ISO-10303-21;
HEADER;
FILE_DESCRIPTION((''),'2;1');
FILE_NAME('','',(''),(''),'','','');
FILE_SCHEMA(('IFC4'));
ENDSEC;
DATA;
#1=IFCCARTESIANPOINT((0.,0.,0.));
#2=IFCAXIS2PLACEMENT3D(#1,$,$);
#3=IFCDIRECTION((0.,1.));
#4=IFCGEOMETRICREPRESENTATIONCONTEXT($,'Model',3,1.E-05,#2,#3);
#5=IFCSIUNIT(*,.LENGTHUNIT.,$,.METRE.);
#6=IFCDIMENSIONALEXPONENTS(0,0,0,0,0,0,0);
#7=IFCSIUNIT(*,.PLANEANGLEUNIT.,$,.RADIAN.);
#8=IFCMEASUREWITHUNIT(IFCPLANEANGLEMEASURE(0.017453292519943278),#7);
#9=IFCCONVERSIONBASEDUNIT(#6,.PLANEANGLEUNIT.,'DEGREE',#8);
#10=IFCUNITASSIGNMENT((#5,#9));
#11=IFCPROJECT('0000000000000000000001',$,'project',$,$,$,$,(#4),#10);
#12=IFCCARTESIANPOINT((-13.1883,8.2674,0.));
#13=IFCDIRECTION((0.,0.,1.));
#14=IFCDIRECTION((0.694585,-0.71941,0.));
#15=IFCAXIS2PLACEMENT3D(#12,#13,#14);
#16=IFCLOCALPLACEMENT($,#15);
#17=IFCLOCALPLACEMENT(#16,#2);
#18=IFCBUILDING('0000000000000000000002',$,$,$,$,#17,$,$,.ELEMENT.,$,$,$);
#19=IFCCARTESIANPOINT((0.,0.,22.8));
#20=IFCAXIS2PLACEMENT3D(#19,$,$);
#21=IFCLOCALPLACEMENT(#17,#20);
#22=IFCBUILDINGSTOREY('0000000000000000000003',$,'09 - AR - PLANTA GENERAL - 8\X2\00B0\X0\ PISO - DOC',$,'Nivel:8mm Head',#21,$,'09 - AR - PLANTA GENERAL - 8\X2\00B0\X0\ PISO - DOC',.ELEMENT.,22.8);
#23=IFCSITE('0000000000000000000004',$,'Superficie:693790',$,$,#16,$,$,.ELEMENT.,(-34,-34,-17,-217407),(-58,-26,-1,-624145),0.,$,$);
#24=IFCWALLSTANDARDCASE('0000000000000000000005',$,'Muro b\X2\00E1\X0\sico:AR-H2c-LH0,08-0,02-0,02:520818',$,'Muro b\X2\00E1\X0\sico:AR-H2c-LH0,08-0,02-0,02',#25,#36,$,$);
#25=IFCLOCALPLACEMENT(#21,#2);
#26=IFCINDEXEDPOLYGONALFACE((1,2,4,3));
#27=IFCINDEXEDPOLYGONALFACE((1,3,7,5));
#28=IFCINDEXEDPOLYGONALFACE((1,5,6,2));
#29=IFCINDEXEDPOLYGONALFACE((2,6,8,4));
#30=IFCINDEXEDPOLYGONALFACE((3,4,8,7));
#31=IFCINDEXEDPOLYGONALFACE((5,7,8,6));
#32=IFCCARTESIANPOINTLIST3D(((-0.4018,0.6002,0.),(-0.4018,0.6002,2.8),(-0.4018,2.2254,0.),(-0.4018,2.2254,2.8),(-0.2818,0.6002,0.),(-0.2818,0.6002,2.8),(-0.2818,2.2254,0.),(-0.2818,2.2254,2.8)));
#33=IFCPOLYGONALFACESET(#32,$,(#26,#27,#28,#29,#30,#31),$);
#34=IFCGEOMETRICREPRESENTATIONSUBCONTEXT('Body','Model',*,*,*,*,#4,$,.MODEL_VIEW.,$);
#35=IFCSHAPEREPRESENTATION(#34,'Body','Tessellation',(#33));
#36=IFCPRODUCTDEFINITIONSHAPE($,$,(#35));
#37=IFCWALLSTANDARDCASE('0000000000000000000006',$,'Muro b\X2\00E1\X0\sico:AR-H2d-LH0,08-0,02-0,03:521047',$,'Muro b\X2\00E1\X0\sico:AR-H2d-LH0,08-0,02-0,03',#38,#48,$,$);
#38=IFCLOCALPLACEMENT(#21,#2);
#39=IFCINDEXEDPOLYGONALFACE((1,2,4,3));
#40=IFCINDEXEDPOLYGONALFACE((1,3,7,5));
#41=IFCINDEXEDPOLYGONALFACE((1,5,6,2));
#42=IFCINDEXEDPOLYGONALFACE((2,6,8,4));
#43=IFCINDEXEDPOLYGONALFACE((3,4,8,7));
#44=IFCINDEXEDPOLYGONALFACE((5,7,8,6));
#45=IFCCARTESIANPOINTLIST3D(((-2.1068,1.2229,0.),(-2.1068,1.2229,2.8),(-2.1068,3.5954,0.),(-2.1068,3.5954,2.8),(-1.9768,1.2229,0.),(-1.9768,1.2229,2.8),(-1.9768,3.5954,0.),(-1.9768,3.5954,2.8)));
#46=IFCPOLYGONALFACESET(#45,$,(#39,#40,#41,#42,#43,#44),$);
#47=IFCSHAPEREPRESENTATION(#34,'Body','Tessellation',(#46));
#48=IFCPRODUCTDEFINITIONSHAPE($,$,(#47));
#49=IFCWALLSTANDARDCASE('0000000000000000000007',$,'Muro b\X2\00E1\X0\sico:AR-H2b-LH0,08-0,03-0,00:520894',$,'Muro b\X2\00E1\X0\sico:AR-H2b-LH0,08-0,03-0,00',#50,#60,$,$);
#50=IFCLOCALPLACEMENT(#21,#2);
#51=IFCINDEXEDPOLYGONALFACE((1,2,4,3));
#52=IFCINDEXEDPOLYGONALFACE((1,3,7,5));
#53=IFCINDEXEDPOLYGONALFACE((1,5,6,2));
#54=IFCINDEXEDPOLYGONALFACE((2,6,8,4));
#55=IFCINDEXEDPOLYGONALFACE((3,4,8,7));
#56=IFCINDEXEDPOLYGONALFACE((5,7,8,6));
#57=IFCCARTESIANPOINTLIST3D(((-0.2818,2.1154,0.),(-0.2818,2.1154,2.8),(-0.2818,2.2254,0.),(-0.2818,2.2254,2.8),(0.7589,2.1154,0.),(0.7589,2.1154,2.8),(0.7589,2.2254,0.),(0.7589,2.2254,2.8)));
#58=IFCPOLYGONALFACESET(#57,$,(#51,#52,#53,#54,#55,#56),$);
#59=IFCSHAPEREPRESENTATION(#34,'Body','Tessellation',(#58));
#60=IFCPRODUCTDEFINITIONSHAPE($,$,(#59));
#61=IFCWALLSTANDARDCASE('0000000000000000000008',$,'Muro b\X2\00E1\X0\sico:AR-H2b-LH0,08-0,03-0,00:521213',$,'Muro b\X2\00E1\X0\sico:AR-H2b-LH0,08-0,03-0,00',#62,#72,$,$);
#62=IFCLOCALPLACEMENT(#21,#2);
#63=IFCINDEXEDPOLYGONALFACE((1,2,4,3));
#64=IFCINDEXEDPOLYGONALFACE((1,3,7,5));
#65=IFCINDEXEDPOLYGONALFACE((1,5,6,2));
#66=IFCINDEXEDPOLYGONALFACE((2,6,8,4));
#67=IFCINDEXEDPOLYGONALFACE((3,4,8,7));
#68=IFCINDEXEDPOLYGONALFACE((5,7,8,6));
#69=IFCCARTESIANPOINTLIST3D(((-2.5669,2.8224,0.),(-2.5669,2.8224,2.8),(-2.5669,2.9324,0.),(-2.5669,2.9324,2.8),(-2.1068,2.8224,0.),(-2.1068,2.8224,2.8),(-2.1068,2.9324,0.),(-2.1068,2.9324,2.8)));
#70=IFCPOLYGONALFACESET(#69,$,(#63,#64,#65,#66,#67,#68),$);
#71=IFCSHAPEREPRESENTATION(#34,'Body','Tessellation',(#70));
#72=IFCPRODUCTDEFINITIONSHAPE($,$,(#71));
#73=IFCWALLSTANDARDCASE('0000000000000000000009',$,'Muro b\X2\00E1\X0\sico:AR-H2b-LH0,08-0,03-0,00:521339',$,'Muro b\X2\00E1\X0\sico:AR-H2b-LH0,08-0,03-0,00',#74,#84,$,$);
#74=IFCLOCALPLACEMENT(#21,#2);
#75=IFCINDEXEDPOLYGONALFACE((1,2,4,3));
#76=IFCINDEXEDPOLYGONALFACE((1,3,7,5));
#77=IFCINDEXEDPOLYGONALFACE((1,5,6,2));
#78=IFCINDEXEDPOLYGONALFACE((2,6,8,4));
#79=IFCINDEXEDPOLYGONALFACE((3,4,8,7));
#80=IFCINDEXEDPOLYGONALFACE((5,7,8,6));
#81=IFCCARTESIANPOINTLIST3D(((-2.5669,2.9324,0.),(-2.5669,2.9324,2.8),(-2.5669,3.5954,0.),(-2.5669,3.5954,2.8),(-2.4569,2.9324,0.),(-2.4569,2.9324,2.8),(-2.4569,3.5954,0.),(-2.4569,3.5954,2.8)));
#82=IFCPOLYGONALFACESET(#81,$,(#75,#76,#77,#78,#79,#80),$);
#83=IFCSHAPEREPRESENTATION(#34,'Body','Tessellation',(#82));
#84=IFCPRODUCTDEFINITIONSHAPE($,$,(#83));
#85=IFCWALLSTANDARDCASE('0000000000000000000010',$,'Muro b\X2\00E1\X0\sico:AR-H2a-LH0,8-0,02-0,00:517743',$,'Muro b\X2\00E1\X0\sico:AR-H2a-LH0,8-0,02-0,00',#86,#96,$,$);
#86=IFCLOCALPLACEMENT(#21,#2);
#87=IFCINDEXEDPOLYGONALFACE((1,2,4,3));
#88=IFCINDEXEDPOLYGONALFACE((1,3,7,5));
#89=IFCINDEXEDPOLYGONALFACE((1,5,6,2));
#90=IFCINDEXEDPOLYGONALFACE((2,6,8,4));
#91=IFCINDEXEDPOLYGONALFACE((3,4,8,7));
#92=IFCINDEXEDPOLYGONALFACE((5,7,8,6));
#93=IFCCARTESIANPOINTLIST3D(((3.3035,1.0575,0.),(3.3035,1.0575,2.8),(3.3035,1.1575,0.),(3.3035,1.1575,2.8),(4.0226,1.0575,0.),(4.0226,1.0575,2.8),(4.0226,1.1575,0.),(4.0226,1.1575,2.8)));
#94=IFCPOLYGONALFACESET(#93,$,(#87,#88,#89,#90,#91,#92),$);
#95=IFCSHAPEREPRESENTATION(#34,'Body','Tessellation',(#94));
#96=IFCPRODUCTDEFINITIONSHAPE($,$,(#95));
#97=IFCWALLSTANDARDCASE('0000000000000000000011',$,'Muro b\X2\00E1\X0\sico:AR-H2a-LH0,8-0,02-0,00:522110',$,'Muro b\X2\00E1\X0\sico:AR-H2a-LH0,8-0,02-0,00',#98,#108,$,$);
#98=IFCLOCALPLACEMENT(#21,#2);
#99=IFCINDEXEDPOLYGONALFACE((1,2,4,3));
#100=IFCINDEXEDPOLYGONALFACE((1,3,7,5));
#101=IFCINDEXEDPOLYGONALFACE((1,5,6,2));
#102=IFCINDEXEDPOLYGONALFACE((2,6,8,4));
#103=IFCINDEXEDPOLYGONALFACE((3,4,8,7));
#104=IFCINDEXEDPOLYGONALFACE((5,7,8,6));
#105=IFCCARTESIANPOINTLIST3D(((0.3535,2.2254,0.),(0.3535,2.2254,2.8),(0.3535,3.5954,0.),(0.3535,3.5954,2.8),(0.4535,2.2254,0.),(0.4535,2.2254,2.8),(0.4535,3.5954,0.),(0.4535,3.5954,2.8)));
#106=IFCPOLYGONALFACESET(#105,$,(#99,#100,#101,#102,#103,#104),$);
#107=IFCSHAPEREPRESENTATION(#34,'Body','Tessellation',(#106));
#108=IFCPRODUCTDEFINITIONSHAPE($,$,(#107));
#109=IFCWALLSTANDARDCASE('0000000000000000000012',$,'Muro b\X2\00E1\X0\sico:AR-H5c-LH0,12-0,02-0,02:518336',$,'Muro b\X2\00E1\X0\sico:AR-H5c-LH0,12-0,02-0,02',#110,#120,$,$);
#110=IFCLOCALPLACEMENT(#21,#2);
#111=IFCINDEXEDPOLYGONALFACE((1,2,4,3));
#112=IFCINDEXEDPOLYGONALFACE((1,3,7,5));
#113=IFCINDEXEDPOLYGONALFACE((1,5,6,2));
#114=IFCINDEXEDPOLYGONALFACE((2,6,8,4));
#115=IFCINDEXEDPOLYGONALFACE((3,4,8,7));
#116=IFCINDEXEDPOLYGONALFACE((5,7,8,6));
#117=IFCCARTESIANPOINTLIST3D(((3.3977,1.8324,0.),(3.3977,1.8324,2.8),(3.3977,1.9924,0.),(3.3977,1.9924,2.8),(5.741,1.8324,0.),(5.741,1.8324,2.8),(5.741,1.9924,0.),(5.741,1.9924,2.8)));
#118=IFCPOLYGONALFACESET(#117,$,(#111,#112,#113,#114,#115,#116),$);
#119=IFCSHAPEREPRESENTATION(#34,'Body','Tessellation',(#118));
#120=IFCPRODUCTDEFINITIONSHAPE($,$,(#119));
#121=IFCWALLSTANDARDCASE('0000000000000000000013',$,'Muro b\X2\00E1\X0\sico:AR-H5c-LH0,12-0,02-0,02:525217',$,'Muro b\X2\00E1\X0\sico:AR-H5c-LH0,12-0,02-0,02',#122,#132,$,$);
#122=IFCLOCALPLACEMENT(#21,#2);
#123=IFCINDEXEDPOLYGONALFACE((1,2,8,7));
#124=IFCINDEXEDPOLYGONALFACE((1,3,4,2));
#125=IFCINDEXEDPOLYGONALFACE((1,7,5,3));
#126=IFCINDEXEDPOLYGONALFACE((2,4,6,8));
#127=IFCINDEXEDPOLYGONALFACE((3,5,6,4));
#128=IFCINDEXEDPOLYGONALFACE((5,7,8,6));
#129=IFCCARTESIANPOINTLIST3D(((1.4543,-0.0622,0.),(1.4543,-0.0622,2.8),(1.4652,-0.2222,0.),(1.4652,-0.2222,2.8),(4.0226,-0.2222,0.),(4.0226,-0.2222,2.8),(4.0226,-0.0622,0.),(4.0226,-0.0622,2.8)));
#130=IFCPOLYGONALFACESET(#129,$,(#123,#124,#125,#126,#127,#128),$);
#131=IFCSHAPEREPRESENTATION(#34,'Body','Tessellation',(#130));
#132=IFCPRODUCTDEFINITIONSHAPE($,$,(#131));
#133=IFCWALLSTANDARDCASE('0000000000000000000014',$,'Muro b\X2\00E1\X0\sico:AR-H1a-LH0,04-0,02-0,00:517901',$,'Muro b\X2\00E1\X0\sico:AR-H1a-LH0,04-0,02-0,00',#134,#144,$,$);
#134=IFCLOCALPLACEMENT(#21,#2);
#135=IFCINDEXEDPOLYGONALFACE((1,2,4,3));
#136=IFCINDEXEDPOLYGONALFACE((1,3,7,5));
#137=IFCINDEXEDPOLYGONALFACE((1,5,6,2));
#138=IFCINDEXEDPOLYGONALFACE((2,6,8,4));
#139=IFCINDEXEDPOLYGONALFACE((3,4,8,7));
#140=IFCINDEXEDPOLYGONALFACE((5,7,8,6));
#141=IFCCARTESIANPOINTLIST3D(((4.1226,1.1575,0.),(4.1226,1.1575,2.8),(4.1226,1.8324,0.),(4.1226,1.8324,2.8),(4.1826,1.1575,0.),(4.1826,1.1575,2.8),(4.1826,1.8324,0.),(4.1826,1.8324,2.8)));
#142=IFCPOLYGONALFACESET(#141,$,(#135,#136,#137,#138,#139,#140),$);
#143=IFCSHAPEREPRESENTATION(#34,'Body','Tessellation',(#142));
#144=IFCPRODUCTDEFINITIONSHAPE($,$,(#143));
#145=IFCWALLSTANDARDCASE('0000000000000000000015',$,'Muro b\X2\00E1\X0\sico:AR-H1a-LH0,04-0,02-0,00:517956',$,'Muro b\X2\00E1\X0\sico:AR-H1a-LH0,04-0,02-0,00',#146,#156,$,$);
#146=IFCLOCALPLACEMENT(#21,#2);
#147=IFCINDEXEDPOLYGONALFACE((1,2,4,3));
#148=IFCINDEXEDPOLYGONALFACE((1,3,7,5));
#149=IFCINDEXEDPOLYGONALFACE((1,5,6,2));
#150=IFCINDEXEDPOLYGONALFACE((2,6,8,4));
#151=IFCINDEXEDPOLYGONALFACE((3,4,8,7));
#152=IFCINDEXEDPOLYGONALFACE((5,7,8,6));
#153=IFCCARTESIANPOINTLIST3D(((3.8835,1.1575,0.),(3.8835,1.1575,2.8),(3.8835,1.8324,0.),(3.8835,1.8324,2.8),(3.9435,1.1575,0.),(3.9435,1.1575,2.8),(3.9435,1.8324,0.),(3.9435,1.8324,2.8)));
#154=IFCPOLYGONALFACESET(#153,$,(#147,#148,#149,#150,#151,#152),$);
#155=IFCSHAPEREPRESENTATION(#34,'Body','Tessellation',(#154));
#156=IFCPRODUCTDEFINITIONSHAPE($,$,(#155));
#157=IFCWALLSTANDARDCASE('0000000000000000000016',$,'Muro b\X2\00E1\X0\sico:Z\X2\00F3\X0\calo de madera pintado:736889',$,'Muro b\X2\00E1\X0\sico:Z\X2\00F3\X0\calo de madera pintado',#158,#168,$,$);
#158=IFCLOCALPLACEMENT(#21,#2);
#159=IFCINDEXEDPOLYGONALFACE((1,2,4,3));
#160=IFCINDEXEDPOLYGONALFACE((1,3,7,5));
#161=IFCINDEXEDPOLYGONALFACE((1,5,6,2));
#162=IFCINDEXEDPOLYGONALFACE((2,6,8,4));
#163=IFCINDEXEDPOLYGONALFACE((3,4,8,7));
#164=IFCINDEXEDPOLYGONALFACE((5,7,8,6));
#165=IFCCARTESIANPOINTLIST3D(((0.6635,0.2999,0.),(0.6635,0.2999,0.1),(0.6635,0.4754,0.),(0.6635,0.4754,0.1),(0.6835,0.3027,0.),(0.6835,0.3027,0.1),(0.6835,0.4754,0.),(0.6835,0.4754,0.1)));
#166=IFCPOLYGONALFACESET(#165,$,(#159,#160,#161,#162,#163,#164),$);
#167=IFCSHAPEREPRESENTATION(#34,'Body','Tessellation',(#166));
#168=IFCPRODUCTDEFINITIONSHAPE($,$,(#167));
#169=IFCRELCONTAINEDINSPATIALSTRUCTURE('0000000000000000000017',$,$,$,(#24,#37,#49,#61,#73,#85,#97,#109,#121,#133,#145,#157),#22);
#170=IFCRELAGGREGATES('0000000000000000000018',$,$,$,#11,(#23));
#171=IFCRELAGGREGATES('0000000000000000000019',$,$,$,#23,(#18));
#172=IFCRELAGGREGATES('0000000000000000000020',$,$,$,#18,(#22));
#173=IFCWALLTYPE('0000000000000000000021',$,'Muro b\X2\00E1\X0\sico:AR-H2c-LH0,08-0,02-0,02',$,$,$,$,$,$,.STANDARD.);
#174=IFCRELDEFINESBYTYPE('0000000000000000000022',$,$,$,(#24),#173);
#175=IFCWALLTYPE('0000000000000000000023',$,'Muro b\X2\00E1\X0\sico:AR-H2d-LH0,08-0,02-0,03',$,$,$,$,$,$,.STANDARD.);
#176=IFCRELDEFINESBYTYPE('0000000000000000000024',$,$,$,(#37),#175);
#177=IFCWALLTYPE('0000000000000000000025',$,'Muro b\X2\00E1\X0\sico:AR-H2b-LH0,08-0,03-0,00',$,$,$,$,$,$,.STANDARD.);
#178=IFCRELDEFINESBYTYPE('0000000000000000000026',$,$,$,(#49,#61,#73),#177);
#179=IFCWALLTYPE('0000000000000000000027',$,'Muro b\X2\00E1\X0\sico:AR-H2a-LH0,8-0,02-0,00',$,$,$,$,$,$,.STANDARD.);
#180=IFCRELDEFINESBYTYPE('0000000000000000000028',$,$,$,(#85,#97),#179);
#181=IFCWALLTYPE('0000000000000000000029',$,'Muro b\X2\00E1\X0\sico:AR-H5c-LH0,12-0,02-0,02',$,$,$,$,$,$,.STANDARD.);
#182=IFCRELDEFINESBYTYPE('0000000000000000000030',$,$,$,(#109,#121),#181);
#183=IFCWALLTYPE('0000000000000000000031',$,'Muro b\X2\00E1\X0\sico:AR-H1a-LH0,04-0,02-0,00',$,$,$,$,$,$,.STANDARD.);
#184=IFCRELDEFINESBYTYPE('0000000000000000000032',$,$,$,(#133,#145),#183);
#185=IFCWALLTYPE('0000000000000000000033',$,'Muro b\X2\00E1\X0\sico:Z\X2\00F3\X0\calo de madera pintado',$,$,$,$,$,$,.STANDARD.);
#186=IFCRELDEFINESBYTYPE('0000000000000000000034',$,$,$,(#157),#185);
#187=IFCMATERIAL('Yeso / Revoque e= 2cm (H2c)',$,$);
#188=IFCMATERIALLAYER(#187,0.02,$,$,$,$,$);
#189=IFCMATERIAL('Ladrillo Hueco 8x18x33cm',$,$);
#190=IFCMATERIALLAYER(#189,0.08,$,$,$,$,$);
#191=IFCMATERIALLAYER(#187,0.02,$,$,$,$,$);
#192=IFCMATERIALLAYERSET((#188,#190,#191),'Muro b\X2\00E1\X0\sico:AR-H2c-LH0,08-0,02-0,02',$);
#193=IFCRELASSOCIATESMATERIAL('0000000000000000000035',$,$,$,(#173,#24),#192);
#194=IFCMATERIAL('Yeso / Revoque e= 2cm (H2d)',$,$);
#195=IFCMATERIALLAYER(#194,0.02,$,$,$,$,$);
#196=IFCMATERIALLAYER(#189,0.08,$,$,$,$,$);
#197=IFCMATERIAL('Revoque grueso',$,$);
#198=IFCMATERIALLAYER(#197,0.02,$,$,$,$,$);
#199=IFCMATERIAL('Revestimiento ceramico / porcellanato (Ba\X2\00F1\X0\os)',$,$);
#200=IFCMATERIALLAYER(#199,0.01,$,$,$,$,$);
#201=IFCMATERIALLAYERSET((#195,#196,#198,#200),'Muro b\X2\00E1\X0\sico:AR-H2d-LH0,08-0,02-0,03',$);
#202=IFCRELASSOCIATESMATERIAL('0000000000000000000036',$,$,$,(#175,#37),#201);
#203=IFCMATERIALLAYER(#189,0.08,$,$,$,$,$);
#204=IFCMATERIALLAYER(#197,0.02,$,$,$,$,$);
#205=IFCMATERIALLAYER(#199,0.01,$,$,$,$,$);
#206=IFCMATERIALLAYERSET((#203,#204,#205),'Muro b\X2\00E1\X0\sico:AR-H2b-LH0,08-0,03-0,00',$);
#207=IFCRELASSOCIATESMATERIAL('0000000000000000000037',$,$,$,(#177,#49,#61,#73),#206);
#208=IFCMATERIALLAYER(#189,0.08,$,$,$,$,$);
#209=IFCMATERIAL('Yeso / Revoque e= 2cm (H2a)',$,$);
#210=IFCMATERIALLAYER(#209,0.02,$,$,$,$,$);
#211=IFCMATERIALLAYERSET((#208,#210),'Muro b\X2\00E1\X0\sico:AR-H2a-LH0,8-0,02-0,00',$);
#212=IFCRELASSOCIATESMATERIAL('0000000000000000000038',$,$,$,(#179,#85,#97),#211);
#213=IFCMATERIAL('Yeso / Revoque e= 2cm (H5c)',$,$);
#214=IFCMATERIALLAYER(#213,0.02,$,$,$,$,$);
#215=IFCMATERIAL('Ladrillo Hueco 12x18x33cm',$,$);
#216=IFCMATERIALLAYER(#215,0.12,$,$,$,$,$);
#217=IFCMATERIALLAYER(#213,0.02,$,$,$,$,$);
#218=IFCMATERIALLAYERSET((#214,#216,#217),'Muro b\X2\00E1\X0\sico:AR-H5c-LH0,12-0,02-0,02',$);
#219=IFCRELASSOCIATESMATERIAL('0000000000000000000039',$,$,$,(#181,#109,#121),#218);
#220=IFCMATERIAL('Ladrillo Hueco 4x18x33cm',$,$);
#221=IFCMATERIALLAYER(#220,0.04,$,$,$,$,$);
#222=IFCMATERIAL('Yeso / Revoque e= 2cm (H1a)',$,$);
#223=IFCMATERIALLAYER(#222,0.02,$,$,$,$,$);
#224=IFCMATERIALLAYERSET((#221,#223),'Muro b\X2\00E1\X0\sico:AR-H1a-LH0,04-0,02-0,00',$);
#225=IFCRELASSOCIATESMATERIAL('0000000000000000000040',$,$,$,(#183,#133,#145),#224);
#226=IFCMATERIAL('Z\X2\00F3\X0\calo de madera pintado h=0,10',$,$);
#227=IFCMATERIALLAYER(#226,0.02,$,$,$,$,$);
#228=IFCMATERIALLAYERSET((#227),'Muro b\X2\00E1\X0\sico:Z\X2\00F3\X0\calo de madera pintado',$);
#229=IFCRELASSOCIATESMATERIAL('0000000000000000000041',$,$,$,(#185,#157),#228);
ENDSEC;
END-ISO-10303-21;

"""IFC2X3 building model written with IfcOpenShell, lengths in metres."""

from ifc_helpers import new_model, entity, si_unit, converted_unit, direction, frame, frame_2d, origin, place, context, subcontext, project, spatial, polyline, rectangle, outline, extrude, material, layer, layer_set, layer_usage, type_object, element, save


model = new_model("IFC2X3")

# Units and contexts
model_context = context("Model", 3, precision=1e-05, world=origin(), true_north=direction((0.0, 1.0)))
body_context = subcontext(model_context, "Body", "Model", "MODEL_VIEW")
ifc_project = project(units=[si_unit("LENGTHUNIT", "METRE"), converted_unit("PLANEANGLEUNIT", "DEGREE", entity("IfcPlaneAngleMeasure", 0.017453292519943278), si_unit("PLANEANGLEUNIT", "RADIAN"), dimensions=[0, 0, 0, 0, 0, 0, 0])], contexts=[model_context])

# Site, building, storey
site_placement = place(None, frame((-13.1883, 8.2674, 0.0), z_axis=(0.0, 0.0, 1.0), x_axis=(0.694585, -0.71941, 0.0)))
site = spatial("IfcSite", under=ifc_project, at=site_placement, Name="Superficie:693790", CompositionType="ELEMENT", RefLatitude=(-34, -34, -17, -217407), RefLongitude=(-58, -26, -1, -624145), RefElevation=0.0)
building_placement = place(site_placement, origin())
building = spatial("IfcBuilding", under=site, at=building_placement, CompositionType="ELEMENT")
storey_placement = place(building_placement, frame((0.0, 0.0, 22.8)))
storey = spatial("IfcBuildingStorey", under=building, at=storey_placement, Name="09 - AR - PLANTA GENERAL - 8° PISO - DOC", ObjectType="Nivel:8mm Head", LongName="09 - AR - PLANTA GENERAL - 8° PISO - DOC", CompositionType="ELEMENT", Elevation=22.8)

# Walls
ifc_material_1 = material(Name="Yeso / Revoque e= 2cm (H2c)")
ifc_layer_1 = layer(ifc_material_1, 0.02)
ifc_material_2 = material(Name="Ladrillo Hueco 8x18x33cm")
ifc_layer_2 = layer(ifc_material_2, 0.08)
ifc_layer_3 = layer(ifc_material_1, 0.02)
ifc_layer_set_1 = layer_set([ifc_layer_1, ifc_layer_2, ifc_layer_3], Name="Muro básico:AR-H2c-LH0,08-0,02-0,02")
ifc_layer_usage_1 = layer_usage(ifc_layer_set_1, "AXIS2", "NEGATIVE", 0.06)
wall_type_1 = type_object("IfcWallType", Name="Muro básico:AR-H2c-LH0,08-0,02-0,02", PredefinedType="STANDARD", material=ifc_layer_set_1)
wall_1_placement = place(storey_placement, frame((-0.3418, 0.6002, 0.0), z_axis=(0.0, 0.0, 1.0), x_axis=(0.0, 1.0, 0.0)))
element("IfcWallStandardCase", 1, at=wall_1_placement, inside=storey, type_object=wall_type_1, material=ifc_layer_usage_1, Name="Muro básico:AR-H2c-LH0,08-0,02-0,02:520818", ObjectType="Muro básico:AR-H2c-LH0,08-0,02-0,02", context=body_context, shape_type="SweptSolid", body=[
    extrude(rectangle(XDim=1.6252, YDim=0.12, at=frame_2d((0.8126, 0.0), x_axis=(-1.0, 0.0))), origin(), (0.0, 0.0, 1.0), 2.8),
])
ifc_material_3 = material(Name="Yeso / Revoque e= 2cm (H2d)")
ifc_layer_4 = layer(ifc_material_3, 0.02)
ifc_layer_5 = layer(ifc_material_2, 0.08)
ifc_material_4 = material(Name="Revoque grueso")
ifc_layer_6 = layer(ifc_material_4, 0.02)
ifc_material_5 = material(Name="Revestimiento ceramico / porcellanato (Baños)")
ifc_layer_7 = layer(ifc_material_5, 0.01)
ifc_layer_set_2 = layer_set([ifc_layer_4, ifc_layer_5, ifc_layer_6, ifc_layer_7], Name="Muro básico:AR-H2d-LH0,08-0,02-0,03")
ifc_layer_usage_2 = layer_usage(ifc_layer_set_2, "AXIS2", "NEGATIVE", 0.065)
wall_type_2 = type_object("IfcWallType", Name="Muro básico:AR-H2d-LH0,08-0,02-0,03", PredefinedType="STANDARD", material=ifc_layer_set_2)
wall_2_placement = place(storey_placement, frame((-2.0418, 3.5954, 0.0), z_axis=(0.0, 0.0, 1.0), x_axis=(0.0, -1.0, 0.0)))
element("IfcWallStandardCase", 2, at=wall_2_placement, inside=storey, type_object=wall_type_2, material=ifc_layer_usage_2, Name="Muro básico:AR-H2d-LH0,08-0,02-0,03:521047", ObjectType="Muro básico:AR-H2d-LH0,08-0,02-0,03", context=body_context, shape_type="SweptSolid", body=[
    extrude(rectangle(XDim=2.3725, YDim=0.13, at=frame_2d((1.1862, 0.0), x_axis=(-1.0, 0.0))), origin(), (0.0, 0.0, 1.0), 2.8),
])
ifc_layer_8 = layer(ifc_material_2, 0.08)
ifc_layer_9 = layer(ifc_material_4, 0.02)
ifc_layer_10 = layer(ifc_material_5, 0.01)
ifc_layer_set_3 = layer_set([ifc_layer_8, ifc_layer_9, ifc_layer_10], Name="Muro básico:AR-H2b-LH0,08-0,03-0,00")
ifc_layer_usage_3 = layer_usage(ifc_layer_set_3, "AXIS2", "POSITIVE", -0.055)
wall_type_3 = type_object("IfcWallType", Name="Muro básico:AR-H2b-LH0,08-0,03-0,00", PredefinedType="STANDARD", material=ifc_layer_set_3)
wall_3_placement = place(storey_placement, frame((-0.2818, 2.1704, 0.0)))
element("IfcWallStandardCase", 3, at=wall_3_placement, inside=storey, type_object=wall_type_3, material=ifc_layer_usage_3, Name="Muro básico:AR-H2b-LH0,08-0,03-0,00:520894", ObjectType="Muro básico:AR-H2b-LH0,08-0,03-0,00", context=body_context, shape_type="SweptSolid", body=[
    extrude(rectangle(XDim=1.0408, YDim=0.11, at=frame_2d((0.5204, 0.0), x_axis=(-1.0, 0.0))), origin(), (0.0, 0.0, 1.0), 2.8),
])
ifc_layer_usage_4 = layer_usage(ifc_layer_set_3, "AXIS2", "POSITIVE", -0.055)
wall_4_placement = place(storey_placement, frame((-2.1068, 2.8774, 0.0), z_axis=(0.0, 0.0, 1.0), x_axis=(-1.0, 0.0, 0.0)))
element("IfcWallStandardCase", 4, at=wall_4_placement, inside=storey, type_object=wall_type_3, material=ifc_layer_usage_4, Name="Muro básico:AR-H2b-LH0,08-0,03-0,00:521213", ObjectType="Muro básico:AR-H2b-LH0,08-0,03-0,00", context=body_context, shape_type="SweptSolid", body=[
    extrude(rectangle(XDim=0.46, YDim=0.11, at=frame_2d((0.23, 0.0), x_axis=(-1.0, 0.0))), origin(), (0.0, 0.0, 1.0), 2.8),
])
ifc_layer_usage_5 = layer_usage(ifc_layer_set_3, "AXIS2", "POSITIVE", -0.055)
wall_5_placement = place(storey_placement, frame((-2.5119, 2.9324, 0.0), z_axis=(0.0, 0.0, 1.0), x_axis=(0.0, 1.0, 0.0)))
element("IfcWallStandardCase", 5, at=wall_5_placement, inside=storey, type_object=wall_type_3, material=ifc_layer_usage_5, Name="Muro básico:AR-H2b-LH0,08-0,03-0,00:521339", ObjectType="Muro básico:AR-H2b-LH0,08-0,03-0,00", context=body_context, shape_type="SweptSolid", body=[
    extrude(rectangle(XDim=0.663, YDim=0.11, at=frame_2d((0.3315, 0.0), x_axis=(-1.0, 0.0))), origin(), (0.0, 0.0, 1.0), 2.8),
])
ifc_layer_11 = layer(ifc_material_2, 0.08)
ifc_material_6 = material(Name="Yeso / Revoque e= 2cm (H2a)")
ifc_layer_12 = layer(ifc_material_6, 0.02)
ifc_layer_set_4 = layer_set([ifc_layer_11, ifc_layer_12], Name="Muro básico:AR-H2a-LH0,8-0,02-0,00")
ifc_layer_usage_6 = layer_usage(ifc_layer_set_4, "AXIS2", "POSITIVE", -0.05)
wall_type_4 = type_object("IfcWallType", Name="Muro básico:AR-H2a-LH0,8-0,02-0,00", PredefinedType="STANDARD", material=ifc_layer_set_4)
wall_6_placement = place(storey_placement, frame((4.0226, 1.1075, 0.0), z_axis=(0.0, 0.0, 1.0), x_axis=(-1.0, 0.0, 0.0)))
element("IfcWallStandardCase", 6, at=wall_6_placement, inside=storey, type_object=wall_type_4, material=ifc_layer_usage_6, Name="Muro básico:AR-H2a-LH0,8-0,02-0,00:517743", ObjectType="Muro básico:AR-H2a-LH0,8-0,02-0,00", context=body_context, shape_type="SweptSolid", body=[
    extrude(rectangle(XDim=0.7191, YDim=0.1, at=frame_2d((0.3595, 0.0), x_axis=(-1.0, 0.0))), origin(), (0.0, 0.0, 1.0), 2.8),
])
ifc_layer_usage_7 = layer_usage(ifc_layer_set_4, "AXIS2", "NEGATIVE", 0.05)
wall_7_placement = place(storey_placement, frame((0.4035, 3.5954, 0.0), z_axis=(0.0, 0.0, 1.0), x_axis=(0.0, -1.0, 0.0)))
element("IfcWallStandardCase", 7, at=wall_7_placement, inside=storey, type_object=wall_type_4, material=ifc_layer_usage_7, Name="Muro básico:AR-H2a-LH0,8-0,02-0,00:522110", ObjectType="Muro básico:AR-H2a-LH0,8-0,02-0,00", context=body_context, shape_type="SweptSolid", body=[
    extrude(rectangle(XDim=1.3701, YDim=0.1, at=frame_2d((0.685, 0.0), x_axis=(-1.0, 0.0))), origin(), (0.0, 0.0, 1.0), 2.8),
])
ifc_material_7 = material(Name="Yeso / Revoque e= 2cm (H5c)")
ifc_layer_13 = layer(ifc_material_7, 0.02)
ifc_material_8 = material(Name="Ladrillo Hueco 12x18x33cm")
ifc_layer_14 = layer(ifc_material_8, 0.12)
ifc_layer_15 = layer(ifc_material_7, 0.02)
ifc_layer_set_5 = layer_set([ifc_layer_13, ifc_layer_14, ifc_layer_15], Name="Muro básico:AR-H5c-LH0,12-0,02-0,02")
ifc_layer_usage_8 = layer_usage(ifc_layer_set_5, "AXIS2", "POSITIVE", -0.08)
wall_type_5 = type_object("IfcWallType", Name="Muro básico:AR-H5c-LH0,12-0,02-0,02", PredefinedType="STANDARD", material=ifc_layer_set_5)
wall_8_placement = place(storey_placement, frame((5.741, 1.9124, 0.0), z_axis=(0.0, 0.0, 1.0), x_axis=(-1.0, 0.0, 0.0)))
element("IfcWallStandardCase", 8, at=wall_8_placement, inside=storey, type_object=wall_type_5, material=ifc_layer_usage_8, Name="Muro básico:AR-H5c-LH0,12-0,02-0,02:518336", ObjectType="Muro básico:AR-H5c-LH0,12-0,02-0,02", context=body_context, shape_type="SweptSolid", body=[
    extrude(rectangle(XDim=2.3433, YDim=0.16, at=frame_2d((1.1716, 0.0), x_axis=(-1.0, 0.0))), origin(), (0.0, 0.0, 1.0), 2.8),
])
ifc_layer_usage_9 = layer_usage(ifc_layer_set_5, "AXIS2", "NEGATIVE", 0.08)
wall_9_placement = place(storey_placement, frame((1.4543, -0.1422, 0.0)))
element("IfcWallStandardCase", 9, at=wall_9_placement, inside=storey, type_object=wall_type_5, material=ifc_layer_usage_9, Name="Muro básico:AR-H5c-LH0,12-0,02-0,02:525217", ObjectType="Muro básico:AR-H5c-LH0,12-0,02-0,02", context=body_context, shape_type="SweptSolid", body=[
    extrude(outline(polyline([(2.5683, -0.08), (2.5683, 0.08), (0.0, 0.08), (0.0109, -0.08), (2.5683, -0.08)])), origin(), (0.0, 0.0, 1.0), 2.8),
])
ifc_material_9 = material(Name="Ladrillo Hueco 4x18x33cm")
ifc_layer_16 = layer(ifc_material_9, 0.04)
ifc_material_10 = material(Name="Yeso / Revoque e= 2cm (H1a)")
ifc_layer_17 = layer(ifc_material_10, 0.02)
ifc_layer_set_6 = layer_set([ifc_layer_16, ifc_layer_17], Name="Muro básico:AR-H1a-LH0,04-0,02-0,00")
ifc_layer_usage_10 = layer_usage(ifc_layer_set_6, "AXIS2", "NEGATIVE", 0.03)
wall_type_6 = type_object("IfcWallType", Name="Muro básico:AR-H1a-LH0,04-0,02-0,00", PredefinedType="STANDARD", material=ifc_layer_set_6)
wall_10_placement = place(storey_placement, frame((4.1526, 1.1575, 0.0), z_axis=(0.0, 0.0, 1.0), x_axis=(0.0, 1.0, 0.0)))
element("IfcWallStandardCase", 10, at=wall_10_placement, inside=storey, type_object=wall_type_6, material=ifc_layer_usage_10, Name="Muro básico:AR-H1a-LH0,04-0,02-0,00:517901", ObjectType="Muro básico:AR-H1a-LH0,04-0,02-0,00", context=body_context, shape_type="SweptSolid", body=[
    extrude(rectangle(XDim=0.675, YDim=0.06, at=frame_2d((0.3375, 0.0), x_axis=(-1.0, 0.0))), origin(), (0.0, 0.0, 1.0), 2.8),
])
ifc_layer_usage_11 = layer_usage(ifc_layer_set_6, "AXIS2", "NEGATIVE", 0.03)
wall_11_placement = place(storey_placement, frame((3.9135, 1.1575, 0.0), z_axis=(0.0, 0.0, 1.0), x_axis=(0.0, 1.0, 0.0)))
element("IfcWallStandardCase", 11, at=wall_11_placement, inside=storey, type_object=wall_type_6, material=ifc_layer_usage_11, Name="Muro básico:AR-H1a-LH0,04-0,02-0,00:517956", ObjectType="Muro básico:AR-H1a-LH0,04-0,02-0,00", context=body_context, shape_type="SweptSolid", body=[
    extrude(rectangle(XDim=0.675, YDim=0.06, at=frame_2d((0.3375, 0.0), x_axis=(-1.0, 0.0))), origin(), (0.0, 0.0, 1.0), 2.8),
])
ifc_material_11 = material(Name="Zócalo de madera pintado h=0,10")
ifc_layer_18 = layer(ifc_material_11, 0.02)
ifc_layer_set_7 = layer_set([ifc_layer_18], Name="Muro básico:Zócalo de madera pintado")
wall_type_7 = type_object("IfcWallType", Name="Muro básico:Zócalo de madera pintado", PredefinedType="STANDARD", material=ifc_layer_set_7)
ifc_layer_usage_12 = layer_usage(ifc_layer_set_7, "AXIS2", "NEGATIVE", 0.01)
wall_12_placement = place(storey_placement, frame((0.6735, 0.2999, 0.0), z_axis=(0.0, 0.0, 1.0), x_axis=(0.0, 1.0, 0.0)))
element("IfcWallStandardCase", 12, at=wall_12_placement, inside=storey, type_object=wall_type_7, material=ifc_layer_usage_12, Name="Muro básico:Zócalo de madera pintado:736889", ObjectType="Muro básico:Zócalo de madera pintado", context=body_context, shape_type="SweptSolid", body=[
    extrude(outline(polyline([(0.1755, -0.01), (0.1755, 0.01), (0.0, 0.01), (0.0027, -0.01), (0.1755, -0.01)])), origin(), (0.0, 0.0, 1.0), 0.1),
])

save(model, "model.ifc")
